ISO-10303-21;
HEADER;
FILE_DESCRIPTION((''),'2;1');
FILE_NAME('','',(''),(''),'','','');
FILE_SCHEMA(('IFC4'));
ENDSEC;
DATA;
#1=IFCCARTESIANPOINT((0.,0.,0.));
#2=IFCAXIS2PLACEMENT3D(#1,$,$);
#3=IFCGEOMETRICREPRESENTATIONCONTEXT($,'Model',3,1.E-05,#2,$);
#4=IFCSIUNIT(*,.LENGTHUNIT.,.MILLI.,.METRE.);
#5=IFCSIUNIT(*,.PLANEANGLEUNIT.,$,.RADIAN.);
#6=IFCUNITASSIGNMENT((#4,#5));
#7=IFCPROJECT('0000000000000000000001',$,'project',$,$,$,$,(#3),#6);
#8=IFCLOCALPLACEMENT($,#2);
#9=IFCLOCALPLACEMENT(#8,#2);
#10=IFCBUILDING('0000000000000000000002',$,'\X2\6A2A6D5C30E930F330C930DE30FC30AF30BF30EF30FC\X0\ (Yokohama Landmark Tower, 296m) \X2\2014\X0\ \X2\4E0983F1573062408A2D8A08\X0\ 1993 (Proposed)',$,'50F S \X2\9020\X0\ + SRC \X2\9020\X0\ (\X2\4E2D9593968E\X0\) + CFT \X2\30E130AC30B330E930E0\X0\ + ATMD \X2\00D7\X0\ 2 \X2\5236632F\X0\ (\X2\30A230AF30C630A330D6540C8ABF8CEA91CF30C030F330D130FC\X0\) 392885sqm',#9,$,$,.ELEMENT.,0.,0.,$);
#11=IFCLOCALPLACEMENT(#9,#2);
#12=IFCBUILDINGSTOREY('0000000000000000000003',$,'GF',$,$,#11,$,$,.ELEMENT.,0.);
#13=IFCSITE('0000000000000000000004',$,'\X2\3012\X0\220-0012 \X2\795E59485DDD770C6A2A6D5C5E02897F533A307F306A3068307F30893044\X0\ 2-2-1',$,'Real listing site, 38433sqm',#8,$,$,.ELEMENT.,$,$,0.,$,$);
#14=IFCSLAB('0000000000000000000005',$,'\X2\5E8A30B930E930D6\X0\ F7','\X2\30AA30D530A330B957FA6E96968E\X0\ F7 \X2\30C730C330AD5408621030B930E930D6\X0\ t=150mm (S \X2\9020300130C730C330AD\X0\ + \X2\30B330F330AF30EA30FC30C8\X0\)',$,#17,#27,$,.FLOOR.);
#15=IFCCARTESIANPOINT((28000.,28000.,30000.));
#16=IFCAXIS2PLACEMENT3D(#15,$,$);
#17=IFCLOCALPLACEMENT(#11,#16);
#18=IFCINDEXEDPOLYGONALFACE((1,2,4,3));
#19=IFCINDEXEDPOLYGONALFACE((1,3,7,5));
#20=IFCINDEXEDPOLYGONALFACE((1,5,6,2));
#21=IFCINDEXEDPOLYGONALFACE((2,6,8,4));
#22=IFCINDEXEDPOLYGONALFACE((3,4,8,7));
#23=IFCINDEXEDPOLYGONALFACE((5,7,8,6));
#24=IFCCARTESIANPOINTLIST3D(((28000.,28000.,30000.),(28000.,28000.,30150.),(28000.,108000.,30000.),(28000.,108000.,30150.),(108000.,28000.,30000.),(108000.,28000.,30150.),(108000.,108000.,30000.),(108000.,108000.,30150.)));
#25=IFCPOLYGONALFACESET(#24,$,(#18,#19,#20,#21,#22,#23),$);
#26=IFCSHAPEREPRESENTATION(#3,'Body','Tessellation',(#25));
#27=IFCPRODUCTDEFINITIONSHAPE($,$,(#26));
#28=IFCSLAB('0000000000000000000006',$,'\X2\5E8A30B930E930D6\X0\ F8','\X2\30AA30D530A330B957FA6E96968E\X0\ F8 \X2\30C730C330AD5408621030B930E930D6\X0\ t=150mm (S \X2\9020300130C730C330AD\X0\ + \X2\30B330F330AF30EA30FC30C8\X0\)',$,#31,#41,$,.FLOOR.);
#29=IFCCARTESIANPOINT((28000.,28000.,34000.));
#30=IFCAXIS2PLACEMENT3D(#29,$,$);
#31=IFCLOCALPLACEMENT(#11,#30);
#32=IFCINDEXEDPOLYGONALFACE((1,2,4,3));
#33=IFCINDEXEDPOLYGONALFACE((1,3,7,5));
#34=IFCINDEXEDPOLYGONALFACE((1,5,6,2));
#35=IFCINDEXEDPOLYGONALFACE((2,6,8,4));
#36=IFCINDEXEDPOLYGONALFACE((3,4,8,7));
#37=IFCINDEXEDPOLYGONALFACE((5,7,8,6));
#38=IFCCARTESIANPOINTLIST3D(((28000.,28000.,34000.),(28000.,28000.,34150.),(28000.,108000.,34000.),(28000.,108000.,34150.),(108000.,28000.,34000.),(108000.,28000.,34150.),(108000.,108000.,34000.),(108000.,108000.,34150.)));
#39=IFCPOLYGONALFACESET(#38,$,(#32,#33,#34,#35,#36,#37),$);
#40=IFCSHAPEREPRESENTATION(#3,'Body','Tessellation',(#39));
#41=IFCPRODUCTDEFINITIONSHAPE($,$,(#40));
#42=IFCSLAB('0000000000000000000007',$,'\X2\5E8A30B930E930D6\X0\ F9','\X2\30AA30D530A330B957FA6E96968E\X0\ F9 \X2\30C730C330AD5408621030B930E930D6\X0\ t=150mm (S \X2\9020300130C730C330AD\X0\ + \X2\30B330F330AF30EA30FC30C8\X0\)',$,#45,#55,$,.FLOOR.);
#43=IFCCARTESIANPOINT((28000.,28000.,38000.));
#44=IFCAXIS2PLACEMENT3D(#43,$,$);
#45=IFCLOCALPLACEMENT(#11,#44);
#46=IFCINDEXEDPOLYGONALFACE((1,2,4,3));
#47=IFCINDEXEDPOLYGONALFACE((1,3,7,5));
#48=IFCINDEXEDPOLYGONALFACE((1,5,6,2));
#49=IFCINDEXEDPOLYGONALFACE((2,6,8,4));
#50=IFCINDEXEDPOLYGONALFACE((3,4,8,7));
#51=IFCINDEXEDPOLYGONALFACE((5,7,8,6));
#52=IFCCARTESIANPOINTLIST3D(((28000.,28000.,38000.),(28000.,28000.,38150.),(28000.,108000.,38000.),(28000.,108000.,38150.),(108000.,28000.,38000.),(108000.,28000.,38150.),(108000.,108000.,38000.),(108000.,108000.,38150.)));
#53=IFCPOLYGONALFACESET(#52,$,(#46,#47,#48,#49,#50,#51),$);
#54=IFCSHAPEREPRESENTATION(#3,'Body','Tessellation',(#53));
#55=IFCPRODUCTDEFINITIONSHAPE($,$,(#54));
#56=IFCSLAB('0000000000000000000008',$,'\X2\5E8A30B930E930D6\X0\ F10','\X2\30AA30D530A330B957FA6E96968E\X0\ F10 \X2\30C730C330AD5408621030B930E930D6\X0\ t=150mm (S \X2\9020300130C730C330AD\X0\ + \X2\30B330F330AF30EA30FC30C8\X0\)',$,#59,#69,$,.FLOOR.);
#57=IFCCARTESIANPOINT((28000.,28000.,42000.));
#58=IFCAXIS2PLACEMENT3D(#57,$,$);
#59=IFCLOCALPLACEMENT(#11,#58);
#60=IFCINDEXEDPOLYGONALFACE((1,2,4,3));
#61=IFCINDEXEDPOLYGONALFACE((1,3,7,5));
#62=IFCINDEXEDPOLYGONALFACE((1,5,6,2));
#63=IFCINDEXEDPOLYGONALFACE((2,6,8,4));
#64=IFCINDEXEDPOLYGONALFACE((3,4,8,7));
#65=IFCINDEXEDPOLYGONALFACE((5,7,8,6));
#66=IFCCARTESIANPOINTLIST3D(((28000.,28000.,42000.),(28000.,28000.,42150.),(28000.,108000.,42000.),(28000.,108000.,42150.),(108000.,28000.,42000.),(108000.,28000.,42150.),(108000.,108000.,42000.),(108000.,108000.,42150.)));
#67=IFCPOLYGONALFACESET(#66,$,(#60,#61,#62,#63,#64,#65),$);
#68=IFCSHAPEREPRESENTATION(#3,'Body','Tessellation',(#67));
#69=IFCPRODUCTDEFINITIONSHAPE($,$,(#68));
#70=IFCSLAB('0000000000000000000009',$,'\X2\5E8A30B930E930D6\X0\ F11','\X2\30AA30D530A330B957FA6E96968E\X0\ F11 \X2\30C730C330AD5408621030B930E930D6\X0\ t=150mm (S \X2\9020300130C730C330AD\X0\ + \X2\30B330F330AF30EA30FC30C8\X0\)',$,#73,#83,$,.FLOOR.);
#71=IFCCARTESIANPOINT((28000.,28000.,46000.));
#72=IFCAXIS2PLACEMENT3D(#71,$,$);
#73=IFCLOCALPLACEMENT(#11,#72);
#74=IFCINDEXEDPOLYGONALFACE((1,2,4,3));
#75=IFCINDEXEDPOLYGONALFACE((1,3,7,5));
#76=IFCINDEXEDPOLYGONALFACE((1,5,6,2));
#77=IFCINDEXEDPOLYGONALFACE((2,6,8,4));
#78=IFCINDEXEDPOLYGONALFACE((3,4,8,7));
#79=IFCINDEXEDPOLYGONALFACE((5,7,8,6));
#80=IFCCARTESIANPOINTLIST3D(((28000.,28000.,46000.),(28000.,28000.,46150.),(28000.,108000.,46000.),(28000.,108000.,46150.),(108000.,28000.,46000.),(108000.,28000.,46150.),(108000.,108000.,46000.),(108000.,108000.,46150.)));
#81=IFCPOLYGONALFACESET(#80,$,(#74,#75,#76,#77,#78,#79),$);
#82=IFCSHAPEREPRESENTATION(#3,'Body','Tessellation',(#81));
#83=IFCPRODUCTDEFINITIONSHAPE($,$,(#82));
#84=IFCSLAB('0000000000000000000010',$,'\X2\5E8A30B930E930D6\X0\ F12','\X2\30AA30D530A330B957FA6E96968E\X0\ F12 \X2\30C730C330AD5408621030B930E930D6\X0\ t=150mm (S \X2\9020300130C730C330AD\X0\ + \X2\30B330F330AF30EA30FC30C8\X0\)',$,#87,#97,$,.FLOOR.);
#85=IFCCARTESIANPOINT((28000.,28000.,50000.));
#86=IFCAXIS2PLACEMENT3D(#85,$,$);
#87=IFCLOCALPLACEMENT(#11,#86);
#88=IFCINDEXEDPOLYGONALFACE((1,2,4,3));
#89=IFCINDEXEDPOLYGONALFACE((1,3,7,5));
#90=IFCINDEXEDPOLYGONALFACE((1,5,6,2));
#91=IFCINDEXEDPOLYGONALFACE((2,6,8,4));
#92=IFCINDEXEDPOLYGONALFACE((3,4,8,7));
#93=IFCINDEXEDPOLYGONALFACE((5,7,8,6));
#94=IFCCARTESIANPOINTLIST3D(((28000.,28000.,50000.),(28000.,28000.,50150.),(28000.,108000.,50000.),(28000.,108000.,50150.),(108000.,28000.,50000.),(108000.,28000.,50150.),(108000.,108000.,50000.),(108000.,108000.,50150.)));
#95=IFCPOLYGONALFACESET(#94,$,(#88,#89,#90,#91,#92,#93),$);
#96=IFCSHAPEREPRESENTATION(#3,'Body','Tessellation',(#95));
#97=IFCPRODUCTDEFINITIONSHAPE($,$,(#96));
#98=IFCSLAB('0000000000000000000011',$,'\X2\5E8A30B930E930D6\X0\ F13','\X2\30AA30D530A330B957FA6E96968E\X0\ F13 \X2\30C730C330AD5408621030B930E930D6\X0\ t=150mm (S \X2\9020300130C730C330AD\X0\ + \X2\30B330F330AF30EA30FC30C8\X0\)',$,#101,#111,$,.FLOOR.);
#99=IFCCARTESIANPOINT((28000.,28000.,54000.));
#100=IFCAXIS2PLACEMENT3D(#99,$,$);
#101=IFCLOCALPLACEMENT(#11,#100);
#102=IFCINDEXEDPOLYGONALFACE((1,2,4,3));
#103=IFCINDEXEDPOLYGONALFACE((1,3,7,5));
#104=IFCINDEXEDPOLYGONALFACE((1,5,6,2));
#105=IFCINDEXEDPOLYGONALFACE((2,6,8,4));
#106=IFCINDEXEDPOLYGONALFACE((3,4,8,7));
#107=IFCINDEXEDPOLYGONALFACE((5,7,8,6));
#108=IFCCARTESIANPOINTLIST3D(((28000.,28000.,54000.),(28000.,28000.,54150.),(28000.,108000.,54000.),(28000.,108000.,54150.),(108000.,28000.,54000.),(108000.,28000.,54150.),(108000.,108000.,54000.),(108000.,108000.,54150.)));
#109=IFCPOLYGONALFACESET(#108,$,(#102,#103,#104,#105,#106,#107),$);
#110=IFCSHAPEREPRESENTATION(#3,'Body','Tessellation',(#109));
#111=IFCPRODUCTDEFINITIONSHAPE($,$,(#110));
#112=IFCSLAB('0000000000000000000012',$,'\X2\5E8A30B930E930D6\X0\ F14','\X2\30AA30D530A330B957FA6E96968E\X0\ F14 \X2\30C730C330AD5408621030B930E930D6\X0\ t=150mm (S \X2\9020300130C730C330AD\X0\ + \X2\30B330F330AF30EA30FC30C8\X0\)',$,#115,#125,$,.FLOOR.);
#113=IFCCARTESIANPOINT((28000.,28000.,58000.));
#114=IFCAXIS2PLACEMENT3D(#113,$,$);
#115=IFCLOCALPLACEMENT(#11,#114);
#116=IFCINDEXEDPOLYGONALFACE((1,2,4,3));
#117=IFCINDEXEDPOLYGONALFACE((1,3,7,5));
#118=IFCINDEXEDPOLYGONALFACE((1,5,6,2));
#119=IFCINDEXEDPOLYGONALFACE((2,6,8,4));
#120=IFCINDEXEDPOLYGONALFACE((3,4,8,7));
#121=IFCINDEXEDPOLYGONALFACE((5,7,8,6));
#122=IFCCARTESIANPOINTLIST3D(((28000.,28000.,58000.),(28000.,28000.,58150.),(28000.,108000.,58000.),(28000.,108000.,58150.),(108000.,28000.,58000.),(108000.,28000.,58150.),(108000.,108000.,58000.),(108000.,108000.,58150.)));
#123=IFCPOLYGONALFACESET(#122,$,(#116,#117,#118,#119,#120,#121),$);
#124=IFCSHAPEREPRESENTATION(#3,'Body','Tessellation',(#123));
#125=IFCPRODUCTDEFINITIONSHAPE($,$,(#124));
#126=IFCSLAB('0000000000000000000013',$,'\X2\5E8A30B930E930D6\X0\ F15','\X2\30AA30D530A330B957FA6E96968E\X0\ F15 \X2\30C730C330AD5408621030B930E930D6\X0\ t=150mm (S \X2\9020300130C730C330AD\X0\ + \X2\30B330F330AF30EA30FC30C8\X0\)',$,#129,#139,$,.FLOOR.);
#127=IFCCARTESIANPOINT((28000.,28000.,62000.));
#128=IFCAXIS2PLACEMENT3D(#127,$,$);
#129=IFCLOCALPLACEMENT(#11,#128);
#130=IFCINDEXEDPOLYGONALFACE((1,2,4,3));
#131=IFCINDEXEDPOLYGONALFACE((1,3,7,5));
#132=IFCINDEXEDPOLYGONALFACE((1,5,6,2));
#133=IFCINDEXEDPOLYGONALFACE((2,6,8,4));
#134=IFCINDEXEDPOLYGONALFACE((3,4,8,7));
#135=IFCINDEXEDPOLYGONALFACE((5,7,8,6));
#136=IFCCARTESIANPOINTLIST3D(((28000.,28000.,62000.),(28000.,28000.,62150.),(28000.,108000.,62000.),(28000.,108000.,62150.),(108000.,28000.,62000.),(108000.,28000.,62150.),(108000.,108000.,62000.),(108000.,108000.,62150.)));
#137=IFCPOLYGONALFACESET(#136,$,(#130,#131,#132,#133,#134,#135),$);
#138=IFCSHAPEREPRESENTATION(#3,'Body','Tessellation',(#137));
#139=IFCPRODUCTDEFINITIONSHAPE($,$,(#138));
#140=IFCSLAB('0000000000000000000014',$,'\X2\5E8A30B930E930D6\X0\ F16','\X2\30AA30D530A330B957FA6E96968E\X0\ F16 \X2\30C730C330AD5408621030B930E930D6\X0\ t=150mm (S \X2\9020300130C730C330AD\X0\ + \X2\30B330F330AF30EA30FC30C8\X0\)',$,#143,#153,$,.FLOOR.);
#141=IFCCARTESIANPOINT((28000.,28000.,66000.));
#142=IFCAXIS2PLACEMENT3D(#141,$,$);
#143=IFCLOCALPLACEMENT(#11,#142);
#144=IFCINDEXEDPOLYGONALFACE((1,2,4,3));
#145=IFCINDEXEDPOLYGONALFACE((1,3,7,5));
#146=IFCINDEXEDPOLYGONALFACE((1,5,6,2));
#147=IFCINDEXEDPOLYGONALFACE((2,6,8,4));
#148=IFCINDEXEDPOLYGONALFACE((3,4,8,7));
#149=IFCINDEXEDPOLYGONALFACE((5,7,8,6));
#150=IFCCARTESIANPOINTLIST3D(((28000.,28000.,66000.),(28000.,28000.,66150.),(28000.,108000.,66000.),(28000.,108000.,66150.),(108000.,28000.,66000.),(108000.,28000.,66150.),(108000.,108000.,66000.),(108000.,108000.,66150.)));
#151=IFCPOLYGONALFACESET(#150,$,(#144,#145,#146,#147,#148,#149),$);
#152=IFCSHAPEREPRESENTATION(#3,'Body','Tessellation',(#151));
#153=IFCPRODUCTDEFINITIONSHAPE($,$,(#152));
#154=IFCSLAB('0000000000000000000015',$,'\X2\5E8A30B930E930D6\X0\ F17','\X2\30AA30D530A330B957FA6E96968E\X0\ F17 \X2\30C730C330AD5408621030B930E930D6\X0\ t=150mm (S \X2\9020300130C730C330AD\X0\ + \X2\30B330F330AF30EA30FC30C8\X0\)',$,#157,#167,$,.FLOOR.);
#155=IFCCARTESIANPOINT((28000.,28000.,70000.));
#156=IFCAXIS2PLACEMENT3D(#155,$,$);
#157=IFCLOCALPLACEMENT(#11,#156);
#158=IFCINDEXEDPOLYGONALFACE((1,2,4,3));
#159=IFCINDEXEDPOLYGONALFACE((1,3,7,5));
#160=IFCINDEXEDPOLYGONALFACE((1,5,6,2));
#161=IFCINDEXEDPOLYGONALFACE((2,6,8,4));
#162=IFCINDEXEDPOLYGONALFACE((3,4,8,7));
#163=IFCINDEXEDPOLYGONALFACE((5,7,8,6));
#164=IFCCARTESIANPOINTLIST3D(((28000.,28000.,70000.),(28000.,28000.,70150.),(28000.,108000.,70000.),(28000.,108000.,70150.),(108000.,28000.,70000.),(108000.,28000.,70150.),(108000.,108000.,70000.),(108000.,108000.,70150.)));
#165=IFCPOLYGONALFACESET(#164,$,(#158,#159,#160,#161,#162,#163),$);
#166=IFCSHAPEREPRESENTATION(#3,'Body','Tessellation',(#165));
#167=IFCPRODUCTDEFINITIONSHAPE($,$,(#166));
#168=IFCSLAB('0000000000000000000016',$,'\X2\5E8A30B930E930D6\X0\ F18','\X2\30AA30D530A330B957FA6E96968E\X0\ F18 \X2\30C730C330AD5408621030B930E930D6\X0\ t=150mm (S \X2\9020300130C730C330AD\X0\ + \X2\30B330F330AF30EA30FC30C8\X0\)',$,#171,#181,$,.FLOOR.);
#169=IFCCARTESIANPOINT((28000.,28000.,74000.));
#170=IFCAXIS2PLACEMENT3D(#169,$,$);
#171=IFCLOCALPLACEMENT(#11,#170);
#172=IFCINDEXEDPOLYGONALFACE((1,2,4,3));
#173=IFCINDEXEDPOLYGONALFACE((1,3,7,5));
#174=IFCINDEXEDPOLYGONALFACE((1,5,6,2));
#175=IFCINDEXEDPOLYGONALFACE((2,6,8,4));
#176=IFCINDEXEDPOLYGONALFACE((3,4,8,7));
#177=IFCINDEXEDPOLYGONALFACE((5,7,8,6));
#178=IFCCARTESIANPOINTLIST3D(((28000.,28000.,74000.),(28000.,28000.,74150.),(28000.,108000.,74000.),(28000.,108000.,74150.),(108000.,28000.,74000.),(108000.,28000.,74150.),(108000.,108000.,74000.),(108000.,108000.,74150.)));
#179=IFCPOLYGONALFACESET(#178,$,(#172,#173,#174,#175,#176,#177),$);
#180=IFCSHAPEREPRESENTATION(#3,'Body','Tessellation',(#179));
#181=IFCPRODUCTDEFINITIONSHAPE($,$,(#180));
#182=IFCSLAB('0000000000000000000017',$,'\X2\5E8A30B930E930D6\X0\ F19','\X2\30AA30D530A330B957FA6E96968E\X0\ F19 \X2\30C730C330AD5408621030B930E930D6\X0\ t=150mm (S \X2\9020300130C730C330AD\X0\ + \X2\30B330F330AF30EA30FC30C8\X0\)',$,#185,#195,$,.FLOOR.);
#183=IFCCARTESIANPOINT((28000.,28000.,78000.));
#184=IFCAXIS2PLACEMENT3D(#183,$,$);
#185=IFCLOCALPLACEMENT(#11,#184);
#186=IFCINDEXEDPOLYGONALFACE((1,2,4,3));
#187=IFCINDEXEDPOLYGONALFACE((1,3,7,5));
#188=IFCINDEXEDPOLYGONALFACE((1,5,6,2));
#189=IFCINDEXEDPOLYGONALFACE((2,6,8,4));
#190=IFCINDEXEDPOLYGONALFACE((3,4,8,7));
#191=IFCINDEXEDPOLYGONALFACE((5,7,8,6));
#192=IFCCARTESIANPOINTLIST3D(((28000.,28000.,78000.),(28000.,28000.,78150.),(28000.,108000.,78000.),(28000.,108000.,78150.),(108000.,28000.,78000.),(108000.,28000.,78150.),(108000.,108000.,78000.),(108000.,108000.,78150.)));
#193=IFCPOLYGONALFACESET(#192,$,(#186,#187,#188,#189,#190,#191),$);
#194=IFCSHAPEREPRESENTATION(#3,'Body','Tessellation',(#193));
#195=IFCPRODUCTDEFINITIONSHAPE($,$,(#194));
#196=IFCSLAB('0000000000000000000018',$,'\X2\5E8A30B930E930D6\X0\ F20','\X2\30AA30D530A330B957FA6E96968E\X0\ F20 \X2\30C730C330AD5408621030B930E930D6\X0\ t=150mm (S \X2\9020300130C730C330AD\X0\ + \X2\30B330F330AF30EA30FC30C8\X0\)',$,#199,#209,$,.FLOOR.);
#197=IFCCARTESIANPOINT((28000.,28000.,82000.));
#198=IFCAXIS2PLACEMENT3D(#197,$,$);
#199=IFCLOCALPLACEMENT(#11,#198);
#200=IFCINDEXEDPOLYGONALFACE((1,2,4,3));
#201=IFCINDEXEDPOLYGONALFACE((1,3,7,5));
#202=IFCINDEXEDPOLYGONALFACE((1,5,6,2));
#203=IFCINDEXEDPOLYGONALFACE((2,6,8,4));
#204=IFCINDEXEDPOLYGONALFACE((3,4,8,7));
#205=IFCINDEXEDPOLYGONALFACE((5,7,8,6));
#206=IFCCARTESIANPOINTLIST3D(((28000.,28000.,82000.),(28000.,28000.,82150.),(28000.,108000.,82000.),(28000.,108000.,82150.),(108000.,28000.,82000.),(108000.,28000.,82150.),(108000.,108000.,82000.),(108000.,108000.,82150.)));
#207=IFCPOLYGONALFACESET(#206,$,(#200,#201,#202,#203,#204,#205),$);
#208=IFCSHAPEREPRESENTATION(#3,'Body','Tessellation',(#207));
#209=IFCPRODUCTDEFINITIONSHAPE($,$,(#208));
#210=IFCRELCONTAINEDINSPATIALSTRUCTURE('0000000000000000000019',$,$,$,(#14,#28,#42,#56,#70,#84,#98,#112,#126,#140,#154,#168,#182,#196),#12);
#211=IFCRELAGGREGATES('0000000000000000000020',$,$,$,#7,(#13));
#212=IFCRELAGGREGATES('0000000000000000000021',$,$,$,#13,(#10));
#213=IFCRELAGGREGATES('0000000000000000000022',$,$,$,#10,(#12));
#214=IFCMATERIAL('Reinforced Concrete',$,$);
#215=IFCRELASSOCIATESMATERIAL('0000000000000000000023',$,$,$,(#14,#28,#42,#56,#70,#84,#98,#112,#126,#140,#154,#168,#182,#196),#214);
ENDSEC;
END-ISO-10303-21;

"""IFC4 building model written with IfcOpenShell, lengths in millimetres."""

from ifc_helpers import new_model, si_unit, frame, frame_2d, origin, place, context, project, spatial, rectangle, extrude, material, element, save


model = new_model("IFC4")

# Units and contexts
model_context = context("Model", 3, precision=1e-05, world=origin())
ifc_project = project(units=[si_unit("LENGTHUNIT", "METRE", prefix="MILLI"), si_unit("PLANEANGLEUNIT", "RADIAN")], contexts=[model_context])

# Site, building, storey
site_placement = place(None, origin())
site = spatial("IfcSite", under=ifc_project, at=site_placement, Name="〒220-0012 神奈川県横浜市西区みなとみらい 2-2-1", ObjectType="Real listing site, 38433sqm", CompositionType="ELEMENT", RefElevation=0.0)
building_placement = place(site_placement, origin())
building = spatial("IfcBuilding", under=site, at=building_placement, Name="横浜ランドマークタワー (Yokohama Landmark Tower, 296m) — 三菱地所設計 1993 (Proposed)", ObjectType="50F S 造 + SRC 造 (中間階) + CFT メガコラム + ATMD × 2 制振 (アクティブ同調質量ダンパー) 392885sqm", CompositionType="ELEMENT", ElevationOfRefHeight=0.0, ElevationOfTerrain=0.0)
storey_placement = place(building_placement, origin())
storey = spatial("IfcBuildingStorey", under=building, at=storey_placement, Name="GF", CompositionType="ELEMENT", Elevation=0.0)

# Shared definitions
ifc_material_1 = material(Name="Reinforced Concrete")

# Slabs
slab_1_placement = place(storey_placement, frame((28000.0, 28000.0, 30000.0)))
element("IfcSlab", 1, at=slab_1_placement, inside=storey, material=ifc_material_1, Name="床スラブ F7", Description="オフィス基準階 F7 デッキ合成スラブ t=150mm (S 造、デッキ + コンクリート)", PredefinedType="FLOOR", context=model_context, shape_type="SweptSolid", body=[
    extrude(rectangle(XDim=80000.0, YDim=80000.0, at=frame_2d((40000.0, 40000.0))), frame((28000.0, 28000.0, 30000.0)), (0.0, 0.0, 1.0), 150.0),
])
slab_2_placement = place(storey_placement, frame((28000.0, 28000.0, 34000.0)))
element("IfcSlab", 2, at=slab_2_placement, inside=storey, material=ifc_material_1, Name="床スラブ F8", Description="オフィス基準階 F8 デッキ合成スラブ t=150mm (S 造、デッキ + コンクリート)", PredefinedType="FLOOR", context=model_context, shape_type="SweptSolid", body=[
    extrude(rectangle(XDim=80000.0, YDim=80000.0, at=frame_2d((40000.0, 40000.0))), frame((28000.0, 28000.0, 34000.0)), (0.0, 0.0, 1.0), 150.0),
])
slab_3_placement = place(storey_placement, frame((28000.0, 28000.0, 38000.0)))
element("IfcSlab", 3, at=slab_3_placement, inside=storey, material=ifc_material_1, Name="床スラブ F9", Description="オフィス基準階 F9 デッキ合成スラブ t=150mm (S 造、デッキ + コンクリート)", PredefinedType="FLOOR", context=model_context, shape_type="SweptSolid", body=[
    extrude(rectangle(XDim=80000.0, YDim=80000.0, at=frame_2d((40000.0, 40000.0))), frame((28000.0, 28000.0, 38000.0)), (0.0, 0.0, 1.0), 150.0),
])
slab_4_placement = place(storey_placement, frame((28000.0, 28000.0, 42000.0)))
element("IfcSlab", 4, at=slab_4_placement, inside=storey, material=ifc_material_1, Name="床スラブ F10", Description="オフィス基準階 F10 デッキ合成スラブ t=150mm (S 造、デッキ + コンクリート)", PredefinedType="FLOOR", context=model_context, shape_type="SweptSolid", body=[
    extrude(rectangle(XDim=80000.0, YDim=80000.0, at=frame_2d((40000.0, 40000.0))), frame((28000.0, 28000.0, 42000.0)), (0.0, 0.0, 1.0), 150.0),
])
slab_5_placement = place(storey_placement, frame((28000.0, 28000.0, 46000.0)))
element("IfcSlab", 5, at=slab_5_placement, inside=storey, material=ifc_material_1, Name="床スラブ F11", Description="オフィス基準階 F11 デッキ合成スラブ t=150mm (S 造、デッキ + コンクリート)", PredefinedType="FLOOR", context=model_context, shape_type="SweptSolid", body=[
    extrude(rectangle(XDim=80000.0, YDim=80000.0, at=frame_2d((40000.0, 40000.0))), frame((28000.0, 28000.0, 46000.0)), (0.0, 0.0, 1.0), 150.0),
])
slab_6_placement = place(storey_placement, frame((28000.0, 28000.0, 50000.0)))
element("IfcSlab", 6, at=slab_6_placement, inside=storey, material=ifc_material_1, Name="床スラブ F12", Description="オフィス基準階 F12 デッキ合成スラブ t=150mm (S 造、デッキ + コンクリート)", PredefinedType="FLOOR", context=model_context, shape_type="SweptSolid", body=[
    extrude(rectangle(XDim=80000.0, YDim=80000.0, at=frame_2d((40000.0, 40000.0))), frame((28000.0, 28000.0, 50000.0)), (0.0, 0.0, 1.0), 150.0),
])
slab_7_placement = place(storey_placement, frame((28000.0, 28000.0, 54000.0)))
element("IfcSlab", 7, at=slab_7_placement, inside=storey, material=ifc_material_1, Name="床スラブ F13", Description="オフィス基準階 F13 デッキ合成スラブ t=150mm (S 造、デッキ + コンクリート)", PredefinedType="FLOOR", context=model_context, shape_type="SweptSolid", body=[
    extrude(rectangle(XDim=80000.0, YDim=80000.0, at=frame_2d((40000.0, 40000.0))), frame((28000.0, 28000.0, 54000.0)), (0.0, 0.0, 1.0), 150.0),
])
slab_8_placement = place(storey_placement, frame((28000.0, 28000.0, 58000.0)))
element("IfcSlab", 8, at=slab_8_placement, inside=storey, material=ifc_material_1, Name="床スラブ F14", Description="オフィス基準階 F14 デッキ合成スラブ t=150mm (S 造、デッキ + コンクリート)", PredefinedType="FLOOR", context=model_context, shape_type="SweptSolid", body=[
    extrude(rectangle(XDim=80000.0, YDim=80000.0, at=frame_2d((40000.0, 40000.0))), frame((28000.0, 28000.0, 58000.0)), (0.0, 0.0, 1.0), 150.0),
])
slab_9_placement = place(storey_placement, frame((28000.0, 28000.0, 62000.0)))
element("IfcSlab", 9, at=slab_9_placement, inside=storey, material=ifc_material_1, Name="床スラブ F15", Description="オフィス基準階 F15 デッキ合成スラブ t=150mm (S 造、デッキ + コンクリート)", PredefinedType="FLOOR", context=model_context, shape_type="SweptSolid", body=[
    extrude(rectangle(XDim=80000.0, YDim=80000.0, at=frame_2d((40000.0, 40000.0))), frame((28000.0, 28000.0, 62000.0)), (0.0, 0.0, 1.0), 150.0),
])
slab_10_placement = place(storey_placement, frame((28000.0, 28000.0, 66000.0)))
element("IfcSlab", 10, at=slab_10_placement, inside=storey, material=ifc_material_1, Name="床スラブ F16", Description="オフィス基準階 F16 デッキ合成スラブ t=150mm (S 造、デッキ + コンクリート)", PredefinedType="FLOOR", context=model_context, shape_type="SweptSolid", body=[
    extrude(rectangle(XDim=80000.0, YDim=80000.0, at=frame_2d((40000.0, 40000.0))), frame((28000.0, 28000.0, 66000.0)), (0.0, 0.0, 1.0), 150.0),
])
slab_11_placement = place(storey_placement, frame((28000.0, 28000.0, 70000.0)))
element("IfcSlab", 11, at=slab_11_placement, inside=storey, material=ifc_material_1, Name="床スラブ F17", Description="オフィス基準階 F17 デッキ合成スラブ t=150mm (S 造、デッキ + コンクリート)", PredefinedType="FLOOR", context=model_context, shape_type="SweptSolid", body=[
    extrude(rectangle(XDim=80000.0, YDim=80000.0, at=frame_2d((40000.0, 40000.0))), frame((28000.0, 28000.0, 70000.0)), (0.0, 0.0, 1.0), 150.0),
])
slab_12_placement = place(storey_placement, frame((28000.0, 28000.0, 74000.0)))
element("IfcSlab", 12, at=slab_12_placement, inside=storey, material=ifc_material_1, Name="床スラブ F18", Description="オフィス基準階 F18 デッキ合成スラブ t=150mm (S 造、デッキ + コンクリート)", PredefinedType="FLOOR", context=model_context, shape_type="SweptSolid", body=[
    extrude(rectangle(XDim=80000.0, YDim=80000.0, at=frame_2d((40000.0, 40000.0))), frame((28000.0, 28000.0, 74000.0)), (0.0, 0.0, 1.0), 150.0),
])
slab_13_placement = place(storey_placement, frame((28000.0, 28000.0, 78000.0)))
element("IfcSlab", 13, at=slab_13_placement, inside=storey, material=ifc_material_1, Name="床スラブ F19", Description="オフィス基準階 F19 デッキ合成スラブ t=150mm (S 造、デッキ + コンクリート)", PredefinedType="FLOOR", context=model_context, shape_type="SweptSolid", body=[
    extrude(rectangle(XDim=80000.0, YDim=80000.0, at=frame_2d((40000.0, 40000.0))), frame((28000.0, 28000.0, 78000.0)), (0.0, 0.0, 1.0), 150.0),
])
slab_14_placement = place(storey_placement, frame((28000.0, 28000.0, 82000.0)))
element("IfcSlab", 14, at=slab_14_placement, inside=storey, material=ifc_material_1, Name="床スラブ F20", Description="オフィス基準階 F20 デッキ合成スラブ t=150mm (S 造、デッキ + コンクリート)", PredefinedType="FLOOR", context=model_context, shape_type="SweptSolid", body=[
    extrude(rectangle(XDim=80000.0, YDim=80000.0, at=frame_2d((40000.0, 40000.0))), frame((28000.0, 28000.0, 82000.0)), (0.0, 0.0, 1.0), 150.0),
])

save(model, "model.ifc")
